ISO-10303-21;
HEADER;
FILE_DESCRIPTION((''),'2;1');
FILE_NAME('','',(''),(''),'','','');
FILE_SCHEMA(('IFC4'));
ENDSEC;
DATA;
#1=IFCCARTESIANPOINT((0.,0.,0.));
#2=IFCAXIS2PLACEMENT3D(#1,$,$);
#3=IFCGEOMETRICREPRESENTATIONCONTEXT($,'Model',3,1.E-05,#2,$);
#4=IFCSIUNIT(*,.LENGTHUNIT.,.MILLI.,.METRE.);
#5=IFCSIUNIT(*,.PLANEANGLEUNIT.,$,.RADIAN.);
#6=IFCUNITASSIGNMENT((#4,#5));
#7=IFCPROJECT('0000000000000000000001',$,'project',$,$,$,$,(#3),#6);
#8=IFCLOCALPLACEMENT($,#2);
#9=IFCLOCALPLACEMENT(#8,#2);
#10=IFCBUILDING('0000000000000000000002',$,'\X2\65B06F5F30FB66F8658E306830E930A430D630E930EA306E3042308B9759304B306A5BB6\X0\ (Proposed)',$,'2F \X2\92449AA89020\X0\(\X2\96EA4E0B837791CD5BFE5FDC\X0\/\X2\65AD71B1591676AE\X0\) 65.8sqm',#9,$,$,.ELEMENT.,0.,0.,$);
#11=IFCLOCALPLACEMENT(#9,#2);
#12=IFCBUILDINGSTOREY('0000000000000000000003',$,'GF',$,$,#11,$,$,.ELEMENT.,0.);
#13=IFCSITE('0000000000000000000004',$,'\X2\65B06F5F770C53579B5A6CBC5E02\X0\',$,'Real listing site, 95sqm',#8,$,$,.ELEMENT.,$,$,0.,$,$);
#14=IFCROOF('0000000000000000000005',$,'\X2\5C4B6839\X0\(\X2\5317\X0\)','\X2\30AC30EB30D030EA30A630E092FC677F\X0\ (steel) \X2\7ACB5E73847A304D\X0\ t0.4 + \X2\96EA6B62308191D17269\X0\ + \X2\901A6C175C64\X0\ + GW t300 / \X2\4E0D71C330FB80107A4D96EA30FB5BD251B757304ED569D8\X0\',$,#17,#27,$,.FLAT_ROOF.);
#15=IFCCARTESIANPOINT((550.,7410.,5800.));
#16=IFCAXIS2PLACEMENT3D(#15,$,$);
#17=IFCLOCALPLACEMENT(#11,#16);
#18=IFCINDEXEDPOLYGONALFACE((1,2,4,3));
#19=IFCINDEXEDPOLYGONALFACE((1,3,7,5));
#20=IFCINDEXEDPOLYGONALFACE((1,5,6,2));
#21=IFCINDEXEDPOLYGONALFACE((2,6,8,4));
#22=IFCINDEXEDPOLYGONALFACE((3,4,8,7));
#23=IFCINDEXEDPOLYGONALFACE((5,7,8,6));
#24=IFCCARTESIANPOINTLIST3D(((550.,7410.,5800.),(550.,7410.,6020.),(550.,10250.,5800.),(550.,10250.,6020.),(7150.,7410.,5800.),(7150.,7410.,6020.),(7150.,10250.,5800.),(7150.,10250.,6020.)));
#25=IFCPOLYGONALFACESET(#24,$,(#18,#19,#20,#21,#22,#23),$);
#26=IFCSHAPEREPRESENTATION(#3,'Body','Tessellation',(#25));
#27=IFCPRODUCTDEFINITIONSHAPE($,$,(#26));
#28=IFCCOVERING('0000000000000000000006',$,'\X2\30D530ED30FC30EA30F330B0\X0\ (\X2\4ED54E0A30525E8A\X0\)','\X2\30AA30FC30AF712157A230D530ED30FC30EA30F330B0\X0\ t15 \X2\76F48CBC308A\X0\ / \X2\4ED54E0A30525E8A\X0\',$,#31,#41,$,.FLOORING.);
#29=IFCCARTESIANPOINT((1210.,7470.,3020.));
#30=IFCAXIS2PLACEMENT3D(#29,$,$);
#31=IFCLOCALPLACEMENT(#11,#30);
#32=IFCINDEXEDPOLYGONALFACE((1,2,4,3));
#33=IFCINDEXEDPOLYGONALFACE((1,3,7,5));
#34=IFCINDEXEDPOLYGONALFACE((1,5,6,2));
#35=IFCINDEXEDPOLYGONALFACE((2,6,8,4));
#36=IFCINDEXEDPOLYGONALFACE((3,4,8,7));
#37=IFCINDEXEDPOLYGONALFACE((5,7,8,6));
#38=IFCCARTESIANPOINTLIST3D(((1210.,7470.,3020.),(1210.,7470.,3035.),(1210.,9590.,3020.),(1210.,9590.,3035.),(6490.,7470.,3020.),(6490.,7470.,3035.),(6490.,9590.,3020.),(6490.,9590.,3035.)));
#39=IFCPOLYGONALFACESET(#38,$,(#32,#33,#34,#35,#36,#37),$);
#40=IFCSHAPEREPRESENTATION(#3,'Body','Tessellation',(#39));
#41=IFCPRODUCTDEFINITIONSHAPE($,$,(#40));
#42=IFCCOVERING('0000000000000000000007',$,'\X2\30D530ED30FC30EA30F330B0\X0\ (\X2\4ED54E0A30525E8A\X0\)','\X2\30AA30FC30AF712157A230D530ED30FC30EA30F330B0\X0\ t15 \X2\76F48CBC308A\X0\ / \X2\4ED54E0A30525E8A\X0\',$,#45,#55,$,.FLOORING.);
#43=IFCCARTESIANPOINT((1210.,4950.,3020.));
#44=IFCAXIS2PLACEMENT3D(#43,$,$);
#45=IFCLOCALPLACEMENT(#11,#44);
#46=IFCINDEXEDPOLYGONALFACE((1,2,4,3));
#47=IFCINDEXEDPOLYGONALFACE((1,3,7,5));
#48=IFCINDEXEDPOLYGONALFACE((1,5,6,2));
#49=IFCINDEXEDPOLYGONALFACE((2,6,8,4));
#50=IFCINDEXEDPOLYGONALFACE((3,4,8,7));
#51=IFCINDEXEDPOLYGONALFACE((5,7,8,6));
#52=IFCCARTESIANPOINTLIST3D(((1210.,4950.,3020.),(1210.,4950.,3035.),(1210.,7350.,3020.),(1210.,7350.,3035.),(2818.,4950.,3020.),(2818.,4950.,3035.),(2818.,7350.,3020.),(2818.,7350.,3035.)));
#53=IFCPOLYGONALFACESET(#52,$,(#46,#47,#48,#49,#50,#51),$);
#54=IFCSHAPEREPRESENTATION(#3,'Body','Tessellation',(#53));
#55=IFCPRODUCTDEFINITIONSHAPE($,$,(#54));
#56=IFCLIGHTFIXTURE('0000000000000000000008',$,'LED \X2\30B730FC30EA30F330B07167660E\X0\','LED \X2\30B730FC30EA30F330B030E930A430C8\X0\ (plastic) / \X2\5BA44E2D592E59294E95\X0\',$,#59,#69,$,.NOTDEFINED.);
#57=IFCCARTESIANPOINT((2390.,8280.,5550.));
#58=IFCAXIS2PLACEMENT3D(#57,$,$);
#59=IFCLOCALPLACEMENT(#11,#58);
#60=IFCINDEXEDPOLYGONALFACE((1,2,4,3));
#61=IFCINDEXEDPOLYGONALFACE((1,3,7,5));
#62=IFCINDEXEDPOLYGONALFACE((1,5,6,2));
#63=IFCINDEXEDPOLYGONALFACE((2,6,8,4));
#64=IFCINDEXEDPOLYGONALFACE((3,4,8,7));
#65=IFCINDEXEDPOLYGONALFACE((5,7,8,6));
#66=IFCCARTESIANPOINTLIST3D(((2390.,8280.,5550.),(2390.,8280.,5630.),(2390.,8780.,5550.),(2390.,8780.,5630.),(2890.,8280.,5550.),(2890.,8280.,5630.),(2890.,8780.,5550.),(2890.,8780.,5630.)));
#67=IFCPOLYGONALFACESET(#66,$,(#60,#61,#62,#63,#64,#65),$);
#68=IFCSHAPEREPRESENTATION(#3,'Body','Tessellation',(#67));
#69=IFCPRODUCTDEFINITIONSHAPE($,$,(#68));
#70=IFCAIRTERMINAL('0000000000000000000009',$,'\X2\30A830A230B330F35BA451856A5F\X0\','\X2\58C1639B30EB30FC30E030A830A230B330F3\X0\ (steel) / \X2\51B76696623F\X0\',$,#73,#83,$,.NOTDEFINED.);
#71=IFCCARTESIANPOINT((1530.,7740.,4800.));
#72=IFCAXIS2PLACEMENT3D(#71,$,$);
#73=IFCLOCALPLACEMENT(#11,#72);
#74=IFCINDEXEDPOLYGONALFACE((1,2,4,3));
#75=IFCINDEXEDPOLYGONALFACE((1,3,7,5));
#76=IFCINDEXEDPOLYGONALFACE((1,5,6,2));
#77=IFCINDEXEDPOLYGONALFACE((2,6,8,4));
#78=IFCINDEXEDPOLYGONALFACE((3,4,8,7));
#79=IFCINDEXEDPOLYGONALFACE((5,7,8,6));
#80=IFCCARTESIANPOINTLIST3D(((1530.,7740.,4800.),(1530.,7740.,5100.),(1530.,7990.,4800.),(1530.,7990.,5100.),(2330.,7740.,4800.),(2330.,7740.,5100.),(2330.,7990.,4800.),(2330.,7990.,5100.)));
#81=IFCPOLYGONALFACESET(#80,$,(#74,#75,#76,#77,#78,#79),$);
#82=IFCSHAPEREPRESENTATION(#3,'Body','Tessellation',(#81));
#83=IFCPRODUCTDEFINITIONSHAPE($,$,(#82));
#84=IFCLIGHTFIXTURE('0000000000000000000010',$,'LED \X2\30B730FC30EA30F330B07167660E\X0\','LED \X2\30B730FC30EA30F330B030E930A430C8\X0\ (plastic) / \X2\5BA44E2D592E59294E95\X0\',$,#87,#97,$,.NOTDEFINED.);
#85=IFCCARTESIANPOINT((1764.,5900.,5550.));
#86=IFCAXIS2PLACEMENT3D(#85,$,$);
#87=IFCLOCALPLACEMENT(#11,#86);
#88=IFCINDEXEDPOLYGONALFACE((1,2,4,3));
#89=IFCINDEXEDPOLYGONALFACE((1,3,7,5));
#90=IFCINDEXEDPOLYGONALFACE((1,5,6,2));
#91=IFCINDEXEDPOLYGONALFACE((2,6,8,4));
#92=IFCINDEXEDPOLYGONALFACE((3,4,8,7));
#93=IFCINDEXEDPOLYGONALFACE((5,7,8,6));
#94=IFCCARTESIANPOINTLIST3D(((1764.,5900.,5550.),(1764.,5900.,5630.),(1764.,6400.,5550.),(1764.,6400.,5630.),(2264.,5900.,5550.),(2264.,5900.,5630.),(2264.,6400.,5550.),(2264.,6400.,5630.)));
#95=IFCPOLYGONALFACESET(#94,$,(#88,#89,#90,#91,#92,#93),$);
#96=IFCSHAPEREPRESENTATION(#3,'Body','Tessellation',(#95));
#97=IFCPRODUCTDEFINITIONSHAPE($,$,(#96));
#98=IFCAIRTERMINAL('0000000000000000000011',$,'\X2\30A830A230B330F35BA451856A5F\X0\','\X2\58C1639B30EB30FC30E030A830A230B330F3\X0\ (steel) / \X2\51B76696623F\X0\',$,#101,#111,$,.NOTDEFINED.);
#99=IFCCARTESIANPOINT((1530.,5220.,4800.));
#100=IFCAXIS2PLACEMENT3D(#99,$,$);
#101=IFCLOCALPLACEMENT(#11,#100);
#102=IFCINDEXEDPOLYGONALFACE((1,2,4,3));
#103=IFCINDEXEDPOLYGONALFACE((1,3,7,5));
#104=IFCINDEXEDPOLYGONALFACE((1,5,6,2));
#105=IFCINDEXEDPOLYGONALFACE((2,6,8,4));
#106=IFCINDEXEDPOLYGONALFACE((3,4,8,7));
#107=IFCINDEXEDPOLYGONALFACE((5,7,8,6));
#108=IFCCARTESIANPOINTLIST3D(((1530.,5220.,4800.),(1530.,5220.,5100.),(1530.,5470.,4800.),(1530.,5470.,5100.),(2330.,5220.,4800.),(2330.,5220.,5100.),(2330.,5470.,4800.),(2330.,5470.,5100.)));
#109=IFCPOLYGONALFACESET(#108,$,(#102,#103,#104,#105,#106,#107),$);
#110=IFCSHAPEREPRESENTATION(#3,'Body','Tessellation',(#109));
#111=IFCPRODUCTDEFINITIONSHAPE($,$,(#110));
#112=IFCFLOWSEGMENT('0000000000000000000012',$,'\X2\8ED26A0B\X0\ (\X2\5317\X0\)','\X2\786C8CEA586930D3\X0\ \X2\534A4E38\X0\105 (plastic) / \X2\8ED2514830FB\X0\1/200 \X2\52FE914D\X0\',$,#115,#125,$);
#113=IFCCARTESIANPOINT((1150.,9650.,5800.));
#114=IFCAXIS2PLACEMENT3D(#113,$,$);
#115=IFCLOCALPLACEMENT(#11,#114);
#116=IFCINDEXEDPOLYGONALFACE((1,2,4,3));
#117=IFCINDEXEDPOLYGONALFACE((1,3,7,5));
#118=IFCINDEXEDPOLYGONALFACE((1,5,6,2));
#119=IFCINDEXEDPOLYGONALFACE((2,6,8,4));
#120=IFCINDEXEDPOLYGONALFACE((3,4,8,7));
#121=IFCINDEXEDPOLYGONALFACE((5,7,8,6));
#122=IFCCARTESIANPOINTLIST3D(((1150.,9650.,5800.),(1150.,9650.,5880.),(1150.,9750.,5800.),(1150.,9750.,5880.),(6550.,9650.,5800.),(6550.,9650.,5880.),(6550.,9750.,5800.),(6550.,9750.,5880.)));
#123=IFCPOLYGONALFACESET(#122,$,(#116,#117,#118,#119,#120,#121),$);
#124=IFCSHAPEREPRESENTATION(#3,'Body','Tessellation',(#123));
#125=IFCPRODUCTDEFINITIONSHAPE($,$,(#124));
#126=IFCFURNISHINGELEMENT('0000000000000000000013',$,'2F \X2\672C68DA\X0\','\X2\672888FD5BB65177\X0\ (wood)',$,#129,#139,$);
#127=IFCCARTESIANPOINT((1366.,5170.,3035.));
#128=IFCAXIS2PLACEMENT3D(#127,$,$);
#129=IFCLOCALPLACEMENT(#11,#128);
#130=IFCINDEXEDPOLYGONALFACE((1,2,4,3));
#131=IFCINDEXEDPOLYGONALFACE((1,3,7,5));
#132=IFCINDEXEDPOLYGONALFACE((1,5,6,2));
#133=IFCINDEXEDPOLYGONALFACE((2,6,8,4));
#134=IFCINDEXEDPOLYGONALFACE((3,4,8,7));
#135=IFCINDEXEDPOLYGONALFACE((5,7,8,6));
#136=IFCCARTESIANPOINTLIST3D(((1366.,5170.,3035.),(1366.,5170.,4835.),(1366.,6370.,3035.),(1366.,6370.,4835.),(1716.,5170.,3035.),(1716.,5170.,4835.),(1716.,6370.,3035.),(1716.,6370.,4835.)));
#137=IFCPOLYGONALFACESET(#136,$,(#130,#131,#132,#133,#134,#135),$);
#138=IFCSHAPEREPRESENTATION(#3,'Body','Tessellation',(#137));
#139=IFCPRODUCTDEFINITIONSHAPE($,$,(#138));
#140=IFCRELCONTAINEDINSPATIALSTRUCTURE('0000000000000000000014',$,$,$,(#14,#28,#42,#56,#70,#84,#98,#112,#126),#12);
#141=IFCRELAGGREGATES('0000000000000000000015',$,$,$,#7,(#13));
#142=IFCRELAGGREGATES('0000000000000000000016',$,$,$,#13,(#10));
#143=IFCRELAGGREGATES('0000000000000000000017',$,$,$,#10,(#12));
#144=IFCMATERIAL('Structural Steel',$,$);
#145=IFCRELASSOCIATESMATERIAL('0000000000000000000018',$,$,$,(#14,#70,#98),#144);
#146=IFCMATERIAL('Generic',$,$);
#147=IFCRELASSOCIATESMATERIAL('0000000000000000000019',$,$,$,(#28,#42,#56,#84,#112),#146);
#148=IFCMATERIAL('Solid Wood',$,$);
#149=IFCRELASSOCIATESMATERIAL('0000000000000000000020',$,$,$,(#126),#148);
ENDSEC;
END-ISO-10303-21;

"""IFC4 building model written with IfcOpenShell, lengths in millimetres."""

from ifc_helpers import new_model, si_unit, frame, frame_2d, origin, place, context, project, spatial, rectangle, extrude, material, element, save


model = new_model("IFC4")

# Units and contexts
model_context = context("Model", 3, precision=1e-05, world=origin())
ifc_project = project(units=[si_unit("LENGTHUNIT", "METRE", prefix="MILLI"), si_unit("PLANEANGLEUNIT", "RADIAN")], contexts=[model_context])

# Site, building, storey
site_placement = place(None, origin())
site = spatial("IfcSite", under=ifc_project, at=site_placement, Name="新潟県南魚沼市", ObjectType="Real listing site, 95sqm", CompositionType="ELEMENT", RefElevation=0.0)
building_placement = place(site_placement, origin())
building = spatial("IfcBuilding", under=site, at=building_placement, Name="新潟・書斎とライブラリのある静かな家 (Proposed)", ObjectType="2F 鉄骨造(雪下荷重対応/断熱外皮) 65.8sqm", CompositionType="ELEMENT", ElevationOfRefHeight=0.0, ElevationOfTerrain=0.0)
storey_placement = place(building_placement, origin())
storey = spatial("IfcBuildingStorey", under=building, at=storey_placement, Name="GF", CompositionType="ELEMENT", Elevation=0.0)

# Shared definitions
ifc_material_1 = material(Name="Solid Wood")

# Roof
ifc_material_2 = material(Name="Structural Steel")
for number, where, name in (
    (1, (550.0, 7410.0, 5800.0), "屋根(北)"),
):
    element("IfcRoof", number, at=place(storey_placement, frame(where)), inside=storey, material=ifc_material_2, Name=name, Description="ガルバリウム鋼板 (steel) 立平葺き t0.4 + 雪止め金物 + 通気層 + GW t300 / 不燃・耐積雪・寒冷地仕様", PredefinedType="FLAT_ROOF", context=model_context, shape_type="SweptSolid", body=[
        extrude(rectangle(XDim=6600.0, YDim=2840.0, at=frame_2d((3300.0, 1420.0))), frame((550.0, 7410.0, 5800.0)), (0.0, 0.0, 1.0), 220.0),
    ])

# Coverings
ifc_material_3 = material(Name="Generic")
covering_1_placement = place(storey_placement, frame((1210.0, 7470.0, 3020.0)))
element("IfcCovering", 2, at=covering_1_placement, inside=storey, material=ifc_material_3, Name="フローリング (仕上げ床)", Description="オーク無垢フローリング t15 直貼り / 仕上げ床", PredefinedType="FLOORING", context=model_context, shape_type="SweptSolid", body=[
    extrude(rectangle(XDim=5280.0, YDim=2120.0, at=frame_2d((2640.0, 1060.0))), frame((1210.0, 7470.0, 3020.0)), (0.0, 0.0, 1.0), 15.0),
])
covering_2_placement = place(storey_placement, frame((1210.0, 4950.0, 3020.0)))
element("IfcCovering", 3, at=covering_2_placement, inside=storey, material=ifc_material_3, Name="フローリング (仕上げ床)", Description="オーク無垢フローリング t15 直貼り / 仕上げ床", PredefinedType="FLOORING", context=model_context, shape_type="SweptSolid", body=[
    extrude(rectangle(XDim=1608.0, YDim=2400.0, at=frame_2d((804.0, 1200.0))), frame((1210.0, 4950.0, 3020.0)), (0.0, 0.0, 1.0), 15.0),
])

# Light fixture
light_fixture_1_placement = place(storey_placement, frame((2390.0, 8280.0, 5550.0)))
element("IfcLightFixture", 4, at=light_fixture_1_placement, inside=storey, material=ifc_material_3, Name="LED シーリング照明", Description="LED シーリングライト (plastic) / 室中央天井", PredefinedType="NOTDEFINED", context=model_context, shape_type="SweptSolid", body=[
    extrude(rectangle(XDim=500.0, YDim=500.0, at=frame_2d((250.0, 250.0))), frame((2390.0, 8280.0, 5550.0)), (0.0, 0.0, 1.0), 80.0),
])

# Air terminal
air_terminal_1_placement = place(storey_placement, frame((1530.0, 7740.0, 4800.0)))
element("IfcAirTerminal", 5, at=air_terminal_1_placement, inside=storey, material=ifc_material_2, Name="エアコン室内機", Description="壁掛ルームエアコン (steel) / 冷暖房", PredefinedType="NOTDEFINED", context=model_context, shape_type="SweptSolid", body=[
    extrude(rectangle(XDim=800.0, YDim=250.0, at=frame_2d((400.0, 125.0))), frame((1530.0, 7740.0, 4800.0)), (0.0, 0.0, 1.0), 300.0),
])

# Light fixture
light_fixture_2_placement = place(storey_placement, frame((1764.0, 5900.0, 5550.0)))
element("IfcLightFixture", 6, at=light_fixture_2_placement, inside=storey, material=ifc_material_3, Name="LED シーリング照明", Description="LED シーリングライト (plastic) / 室中央天井", PredefinedType="NOTDEFINED", context=model_context, shape_type="SweptSolid", body=[
    extrude(rectangle(XDim=500.0, YDim=500.0, at=frame_2d((250.0, 250.0))), frame((1764.0, 5900.0, 5550.0)), (0.0, 0.0, 1.0), 80.0),
])

# Air terminal
air_terminal_2_placement = place(storey_placement, frame((1530.0, 5220.0, 4800.0)))
element("IfcAirTerminal", 7, at=air_terminal_2_placement, inside=storey, material=ifc_material_2, Name="エアコン室内機", Description="壁掛ルームエアコン (steel) / 冷暖房", PredefinedType="NOTDEFINED", context=model_context, shape_type="SweptSolid", body=[
    extrude(rectangle(XDim=800.0, YDim=250.0, at=frame_2d((400.0, 125.0))), frame((1530.0, 5220.0, 4800.0)), (0.0, 0.0, 1.0), 300.0),
])

# Flow segment
flow_segment_placement = place(storey_placement, frame((1150.0, 9650.0, 5800.0)))
element("IfcFlowSegment", 8, at=flow_segment_placement, inside=storey, material=ifc_material_3, Name="軒樋 (北)", Description="硬質塩ビ 半丸105 (plastic) / 軒先・1/200 勾配", context=model_context, shape_type="SweptSolid", body=[
    extrude(rectangle(XDim=5400.0, YDim=100.0, at=frame_2d((2700.0, 50.0))), frame((1150.0, 9650.0, 5800.0)), (0.0, 0.0, 1.0), 80.0),
])

# Furnishing element
furnishing_placement = place(storey_placement, frame((1366.0, 5170.0, 3035.0)))
element("IfcFurnishingElement", 9, at=furnishing_placement, inside=storey, material=ifc_material_1, Name="2F 本棚", Description="木製家具 (wood)", context=model_context, shape_type="SweptSolid", body=[
    extrude(rectangle(XDim=350.0, YDim=1200.0, at=frame_2d((175.0, 600.0))), frame((1366.0, 5170.0, 3035.0)), (0.0, 0.0, 1.0), 1800.0),
])

save(model, "model.ifc")
